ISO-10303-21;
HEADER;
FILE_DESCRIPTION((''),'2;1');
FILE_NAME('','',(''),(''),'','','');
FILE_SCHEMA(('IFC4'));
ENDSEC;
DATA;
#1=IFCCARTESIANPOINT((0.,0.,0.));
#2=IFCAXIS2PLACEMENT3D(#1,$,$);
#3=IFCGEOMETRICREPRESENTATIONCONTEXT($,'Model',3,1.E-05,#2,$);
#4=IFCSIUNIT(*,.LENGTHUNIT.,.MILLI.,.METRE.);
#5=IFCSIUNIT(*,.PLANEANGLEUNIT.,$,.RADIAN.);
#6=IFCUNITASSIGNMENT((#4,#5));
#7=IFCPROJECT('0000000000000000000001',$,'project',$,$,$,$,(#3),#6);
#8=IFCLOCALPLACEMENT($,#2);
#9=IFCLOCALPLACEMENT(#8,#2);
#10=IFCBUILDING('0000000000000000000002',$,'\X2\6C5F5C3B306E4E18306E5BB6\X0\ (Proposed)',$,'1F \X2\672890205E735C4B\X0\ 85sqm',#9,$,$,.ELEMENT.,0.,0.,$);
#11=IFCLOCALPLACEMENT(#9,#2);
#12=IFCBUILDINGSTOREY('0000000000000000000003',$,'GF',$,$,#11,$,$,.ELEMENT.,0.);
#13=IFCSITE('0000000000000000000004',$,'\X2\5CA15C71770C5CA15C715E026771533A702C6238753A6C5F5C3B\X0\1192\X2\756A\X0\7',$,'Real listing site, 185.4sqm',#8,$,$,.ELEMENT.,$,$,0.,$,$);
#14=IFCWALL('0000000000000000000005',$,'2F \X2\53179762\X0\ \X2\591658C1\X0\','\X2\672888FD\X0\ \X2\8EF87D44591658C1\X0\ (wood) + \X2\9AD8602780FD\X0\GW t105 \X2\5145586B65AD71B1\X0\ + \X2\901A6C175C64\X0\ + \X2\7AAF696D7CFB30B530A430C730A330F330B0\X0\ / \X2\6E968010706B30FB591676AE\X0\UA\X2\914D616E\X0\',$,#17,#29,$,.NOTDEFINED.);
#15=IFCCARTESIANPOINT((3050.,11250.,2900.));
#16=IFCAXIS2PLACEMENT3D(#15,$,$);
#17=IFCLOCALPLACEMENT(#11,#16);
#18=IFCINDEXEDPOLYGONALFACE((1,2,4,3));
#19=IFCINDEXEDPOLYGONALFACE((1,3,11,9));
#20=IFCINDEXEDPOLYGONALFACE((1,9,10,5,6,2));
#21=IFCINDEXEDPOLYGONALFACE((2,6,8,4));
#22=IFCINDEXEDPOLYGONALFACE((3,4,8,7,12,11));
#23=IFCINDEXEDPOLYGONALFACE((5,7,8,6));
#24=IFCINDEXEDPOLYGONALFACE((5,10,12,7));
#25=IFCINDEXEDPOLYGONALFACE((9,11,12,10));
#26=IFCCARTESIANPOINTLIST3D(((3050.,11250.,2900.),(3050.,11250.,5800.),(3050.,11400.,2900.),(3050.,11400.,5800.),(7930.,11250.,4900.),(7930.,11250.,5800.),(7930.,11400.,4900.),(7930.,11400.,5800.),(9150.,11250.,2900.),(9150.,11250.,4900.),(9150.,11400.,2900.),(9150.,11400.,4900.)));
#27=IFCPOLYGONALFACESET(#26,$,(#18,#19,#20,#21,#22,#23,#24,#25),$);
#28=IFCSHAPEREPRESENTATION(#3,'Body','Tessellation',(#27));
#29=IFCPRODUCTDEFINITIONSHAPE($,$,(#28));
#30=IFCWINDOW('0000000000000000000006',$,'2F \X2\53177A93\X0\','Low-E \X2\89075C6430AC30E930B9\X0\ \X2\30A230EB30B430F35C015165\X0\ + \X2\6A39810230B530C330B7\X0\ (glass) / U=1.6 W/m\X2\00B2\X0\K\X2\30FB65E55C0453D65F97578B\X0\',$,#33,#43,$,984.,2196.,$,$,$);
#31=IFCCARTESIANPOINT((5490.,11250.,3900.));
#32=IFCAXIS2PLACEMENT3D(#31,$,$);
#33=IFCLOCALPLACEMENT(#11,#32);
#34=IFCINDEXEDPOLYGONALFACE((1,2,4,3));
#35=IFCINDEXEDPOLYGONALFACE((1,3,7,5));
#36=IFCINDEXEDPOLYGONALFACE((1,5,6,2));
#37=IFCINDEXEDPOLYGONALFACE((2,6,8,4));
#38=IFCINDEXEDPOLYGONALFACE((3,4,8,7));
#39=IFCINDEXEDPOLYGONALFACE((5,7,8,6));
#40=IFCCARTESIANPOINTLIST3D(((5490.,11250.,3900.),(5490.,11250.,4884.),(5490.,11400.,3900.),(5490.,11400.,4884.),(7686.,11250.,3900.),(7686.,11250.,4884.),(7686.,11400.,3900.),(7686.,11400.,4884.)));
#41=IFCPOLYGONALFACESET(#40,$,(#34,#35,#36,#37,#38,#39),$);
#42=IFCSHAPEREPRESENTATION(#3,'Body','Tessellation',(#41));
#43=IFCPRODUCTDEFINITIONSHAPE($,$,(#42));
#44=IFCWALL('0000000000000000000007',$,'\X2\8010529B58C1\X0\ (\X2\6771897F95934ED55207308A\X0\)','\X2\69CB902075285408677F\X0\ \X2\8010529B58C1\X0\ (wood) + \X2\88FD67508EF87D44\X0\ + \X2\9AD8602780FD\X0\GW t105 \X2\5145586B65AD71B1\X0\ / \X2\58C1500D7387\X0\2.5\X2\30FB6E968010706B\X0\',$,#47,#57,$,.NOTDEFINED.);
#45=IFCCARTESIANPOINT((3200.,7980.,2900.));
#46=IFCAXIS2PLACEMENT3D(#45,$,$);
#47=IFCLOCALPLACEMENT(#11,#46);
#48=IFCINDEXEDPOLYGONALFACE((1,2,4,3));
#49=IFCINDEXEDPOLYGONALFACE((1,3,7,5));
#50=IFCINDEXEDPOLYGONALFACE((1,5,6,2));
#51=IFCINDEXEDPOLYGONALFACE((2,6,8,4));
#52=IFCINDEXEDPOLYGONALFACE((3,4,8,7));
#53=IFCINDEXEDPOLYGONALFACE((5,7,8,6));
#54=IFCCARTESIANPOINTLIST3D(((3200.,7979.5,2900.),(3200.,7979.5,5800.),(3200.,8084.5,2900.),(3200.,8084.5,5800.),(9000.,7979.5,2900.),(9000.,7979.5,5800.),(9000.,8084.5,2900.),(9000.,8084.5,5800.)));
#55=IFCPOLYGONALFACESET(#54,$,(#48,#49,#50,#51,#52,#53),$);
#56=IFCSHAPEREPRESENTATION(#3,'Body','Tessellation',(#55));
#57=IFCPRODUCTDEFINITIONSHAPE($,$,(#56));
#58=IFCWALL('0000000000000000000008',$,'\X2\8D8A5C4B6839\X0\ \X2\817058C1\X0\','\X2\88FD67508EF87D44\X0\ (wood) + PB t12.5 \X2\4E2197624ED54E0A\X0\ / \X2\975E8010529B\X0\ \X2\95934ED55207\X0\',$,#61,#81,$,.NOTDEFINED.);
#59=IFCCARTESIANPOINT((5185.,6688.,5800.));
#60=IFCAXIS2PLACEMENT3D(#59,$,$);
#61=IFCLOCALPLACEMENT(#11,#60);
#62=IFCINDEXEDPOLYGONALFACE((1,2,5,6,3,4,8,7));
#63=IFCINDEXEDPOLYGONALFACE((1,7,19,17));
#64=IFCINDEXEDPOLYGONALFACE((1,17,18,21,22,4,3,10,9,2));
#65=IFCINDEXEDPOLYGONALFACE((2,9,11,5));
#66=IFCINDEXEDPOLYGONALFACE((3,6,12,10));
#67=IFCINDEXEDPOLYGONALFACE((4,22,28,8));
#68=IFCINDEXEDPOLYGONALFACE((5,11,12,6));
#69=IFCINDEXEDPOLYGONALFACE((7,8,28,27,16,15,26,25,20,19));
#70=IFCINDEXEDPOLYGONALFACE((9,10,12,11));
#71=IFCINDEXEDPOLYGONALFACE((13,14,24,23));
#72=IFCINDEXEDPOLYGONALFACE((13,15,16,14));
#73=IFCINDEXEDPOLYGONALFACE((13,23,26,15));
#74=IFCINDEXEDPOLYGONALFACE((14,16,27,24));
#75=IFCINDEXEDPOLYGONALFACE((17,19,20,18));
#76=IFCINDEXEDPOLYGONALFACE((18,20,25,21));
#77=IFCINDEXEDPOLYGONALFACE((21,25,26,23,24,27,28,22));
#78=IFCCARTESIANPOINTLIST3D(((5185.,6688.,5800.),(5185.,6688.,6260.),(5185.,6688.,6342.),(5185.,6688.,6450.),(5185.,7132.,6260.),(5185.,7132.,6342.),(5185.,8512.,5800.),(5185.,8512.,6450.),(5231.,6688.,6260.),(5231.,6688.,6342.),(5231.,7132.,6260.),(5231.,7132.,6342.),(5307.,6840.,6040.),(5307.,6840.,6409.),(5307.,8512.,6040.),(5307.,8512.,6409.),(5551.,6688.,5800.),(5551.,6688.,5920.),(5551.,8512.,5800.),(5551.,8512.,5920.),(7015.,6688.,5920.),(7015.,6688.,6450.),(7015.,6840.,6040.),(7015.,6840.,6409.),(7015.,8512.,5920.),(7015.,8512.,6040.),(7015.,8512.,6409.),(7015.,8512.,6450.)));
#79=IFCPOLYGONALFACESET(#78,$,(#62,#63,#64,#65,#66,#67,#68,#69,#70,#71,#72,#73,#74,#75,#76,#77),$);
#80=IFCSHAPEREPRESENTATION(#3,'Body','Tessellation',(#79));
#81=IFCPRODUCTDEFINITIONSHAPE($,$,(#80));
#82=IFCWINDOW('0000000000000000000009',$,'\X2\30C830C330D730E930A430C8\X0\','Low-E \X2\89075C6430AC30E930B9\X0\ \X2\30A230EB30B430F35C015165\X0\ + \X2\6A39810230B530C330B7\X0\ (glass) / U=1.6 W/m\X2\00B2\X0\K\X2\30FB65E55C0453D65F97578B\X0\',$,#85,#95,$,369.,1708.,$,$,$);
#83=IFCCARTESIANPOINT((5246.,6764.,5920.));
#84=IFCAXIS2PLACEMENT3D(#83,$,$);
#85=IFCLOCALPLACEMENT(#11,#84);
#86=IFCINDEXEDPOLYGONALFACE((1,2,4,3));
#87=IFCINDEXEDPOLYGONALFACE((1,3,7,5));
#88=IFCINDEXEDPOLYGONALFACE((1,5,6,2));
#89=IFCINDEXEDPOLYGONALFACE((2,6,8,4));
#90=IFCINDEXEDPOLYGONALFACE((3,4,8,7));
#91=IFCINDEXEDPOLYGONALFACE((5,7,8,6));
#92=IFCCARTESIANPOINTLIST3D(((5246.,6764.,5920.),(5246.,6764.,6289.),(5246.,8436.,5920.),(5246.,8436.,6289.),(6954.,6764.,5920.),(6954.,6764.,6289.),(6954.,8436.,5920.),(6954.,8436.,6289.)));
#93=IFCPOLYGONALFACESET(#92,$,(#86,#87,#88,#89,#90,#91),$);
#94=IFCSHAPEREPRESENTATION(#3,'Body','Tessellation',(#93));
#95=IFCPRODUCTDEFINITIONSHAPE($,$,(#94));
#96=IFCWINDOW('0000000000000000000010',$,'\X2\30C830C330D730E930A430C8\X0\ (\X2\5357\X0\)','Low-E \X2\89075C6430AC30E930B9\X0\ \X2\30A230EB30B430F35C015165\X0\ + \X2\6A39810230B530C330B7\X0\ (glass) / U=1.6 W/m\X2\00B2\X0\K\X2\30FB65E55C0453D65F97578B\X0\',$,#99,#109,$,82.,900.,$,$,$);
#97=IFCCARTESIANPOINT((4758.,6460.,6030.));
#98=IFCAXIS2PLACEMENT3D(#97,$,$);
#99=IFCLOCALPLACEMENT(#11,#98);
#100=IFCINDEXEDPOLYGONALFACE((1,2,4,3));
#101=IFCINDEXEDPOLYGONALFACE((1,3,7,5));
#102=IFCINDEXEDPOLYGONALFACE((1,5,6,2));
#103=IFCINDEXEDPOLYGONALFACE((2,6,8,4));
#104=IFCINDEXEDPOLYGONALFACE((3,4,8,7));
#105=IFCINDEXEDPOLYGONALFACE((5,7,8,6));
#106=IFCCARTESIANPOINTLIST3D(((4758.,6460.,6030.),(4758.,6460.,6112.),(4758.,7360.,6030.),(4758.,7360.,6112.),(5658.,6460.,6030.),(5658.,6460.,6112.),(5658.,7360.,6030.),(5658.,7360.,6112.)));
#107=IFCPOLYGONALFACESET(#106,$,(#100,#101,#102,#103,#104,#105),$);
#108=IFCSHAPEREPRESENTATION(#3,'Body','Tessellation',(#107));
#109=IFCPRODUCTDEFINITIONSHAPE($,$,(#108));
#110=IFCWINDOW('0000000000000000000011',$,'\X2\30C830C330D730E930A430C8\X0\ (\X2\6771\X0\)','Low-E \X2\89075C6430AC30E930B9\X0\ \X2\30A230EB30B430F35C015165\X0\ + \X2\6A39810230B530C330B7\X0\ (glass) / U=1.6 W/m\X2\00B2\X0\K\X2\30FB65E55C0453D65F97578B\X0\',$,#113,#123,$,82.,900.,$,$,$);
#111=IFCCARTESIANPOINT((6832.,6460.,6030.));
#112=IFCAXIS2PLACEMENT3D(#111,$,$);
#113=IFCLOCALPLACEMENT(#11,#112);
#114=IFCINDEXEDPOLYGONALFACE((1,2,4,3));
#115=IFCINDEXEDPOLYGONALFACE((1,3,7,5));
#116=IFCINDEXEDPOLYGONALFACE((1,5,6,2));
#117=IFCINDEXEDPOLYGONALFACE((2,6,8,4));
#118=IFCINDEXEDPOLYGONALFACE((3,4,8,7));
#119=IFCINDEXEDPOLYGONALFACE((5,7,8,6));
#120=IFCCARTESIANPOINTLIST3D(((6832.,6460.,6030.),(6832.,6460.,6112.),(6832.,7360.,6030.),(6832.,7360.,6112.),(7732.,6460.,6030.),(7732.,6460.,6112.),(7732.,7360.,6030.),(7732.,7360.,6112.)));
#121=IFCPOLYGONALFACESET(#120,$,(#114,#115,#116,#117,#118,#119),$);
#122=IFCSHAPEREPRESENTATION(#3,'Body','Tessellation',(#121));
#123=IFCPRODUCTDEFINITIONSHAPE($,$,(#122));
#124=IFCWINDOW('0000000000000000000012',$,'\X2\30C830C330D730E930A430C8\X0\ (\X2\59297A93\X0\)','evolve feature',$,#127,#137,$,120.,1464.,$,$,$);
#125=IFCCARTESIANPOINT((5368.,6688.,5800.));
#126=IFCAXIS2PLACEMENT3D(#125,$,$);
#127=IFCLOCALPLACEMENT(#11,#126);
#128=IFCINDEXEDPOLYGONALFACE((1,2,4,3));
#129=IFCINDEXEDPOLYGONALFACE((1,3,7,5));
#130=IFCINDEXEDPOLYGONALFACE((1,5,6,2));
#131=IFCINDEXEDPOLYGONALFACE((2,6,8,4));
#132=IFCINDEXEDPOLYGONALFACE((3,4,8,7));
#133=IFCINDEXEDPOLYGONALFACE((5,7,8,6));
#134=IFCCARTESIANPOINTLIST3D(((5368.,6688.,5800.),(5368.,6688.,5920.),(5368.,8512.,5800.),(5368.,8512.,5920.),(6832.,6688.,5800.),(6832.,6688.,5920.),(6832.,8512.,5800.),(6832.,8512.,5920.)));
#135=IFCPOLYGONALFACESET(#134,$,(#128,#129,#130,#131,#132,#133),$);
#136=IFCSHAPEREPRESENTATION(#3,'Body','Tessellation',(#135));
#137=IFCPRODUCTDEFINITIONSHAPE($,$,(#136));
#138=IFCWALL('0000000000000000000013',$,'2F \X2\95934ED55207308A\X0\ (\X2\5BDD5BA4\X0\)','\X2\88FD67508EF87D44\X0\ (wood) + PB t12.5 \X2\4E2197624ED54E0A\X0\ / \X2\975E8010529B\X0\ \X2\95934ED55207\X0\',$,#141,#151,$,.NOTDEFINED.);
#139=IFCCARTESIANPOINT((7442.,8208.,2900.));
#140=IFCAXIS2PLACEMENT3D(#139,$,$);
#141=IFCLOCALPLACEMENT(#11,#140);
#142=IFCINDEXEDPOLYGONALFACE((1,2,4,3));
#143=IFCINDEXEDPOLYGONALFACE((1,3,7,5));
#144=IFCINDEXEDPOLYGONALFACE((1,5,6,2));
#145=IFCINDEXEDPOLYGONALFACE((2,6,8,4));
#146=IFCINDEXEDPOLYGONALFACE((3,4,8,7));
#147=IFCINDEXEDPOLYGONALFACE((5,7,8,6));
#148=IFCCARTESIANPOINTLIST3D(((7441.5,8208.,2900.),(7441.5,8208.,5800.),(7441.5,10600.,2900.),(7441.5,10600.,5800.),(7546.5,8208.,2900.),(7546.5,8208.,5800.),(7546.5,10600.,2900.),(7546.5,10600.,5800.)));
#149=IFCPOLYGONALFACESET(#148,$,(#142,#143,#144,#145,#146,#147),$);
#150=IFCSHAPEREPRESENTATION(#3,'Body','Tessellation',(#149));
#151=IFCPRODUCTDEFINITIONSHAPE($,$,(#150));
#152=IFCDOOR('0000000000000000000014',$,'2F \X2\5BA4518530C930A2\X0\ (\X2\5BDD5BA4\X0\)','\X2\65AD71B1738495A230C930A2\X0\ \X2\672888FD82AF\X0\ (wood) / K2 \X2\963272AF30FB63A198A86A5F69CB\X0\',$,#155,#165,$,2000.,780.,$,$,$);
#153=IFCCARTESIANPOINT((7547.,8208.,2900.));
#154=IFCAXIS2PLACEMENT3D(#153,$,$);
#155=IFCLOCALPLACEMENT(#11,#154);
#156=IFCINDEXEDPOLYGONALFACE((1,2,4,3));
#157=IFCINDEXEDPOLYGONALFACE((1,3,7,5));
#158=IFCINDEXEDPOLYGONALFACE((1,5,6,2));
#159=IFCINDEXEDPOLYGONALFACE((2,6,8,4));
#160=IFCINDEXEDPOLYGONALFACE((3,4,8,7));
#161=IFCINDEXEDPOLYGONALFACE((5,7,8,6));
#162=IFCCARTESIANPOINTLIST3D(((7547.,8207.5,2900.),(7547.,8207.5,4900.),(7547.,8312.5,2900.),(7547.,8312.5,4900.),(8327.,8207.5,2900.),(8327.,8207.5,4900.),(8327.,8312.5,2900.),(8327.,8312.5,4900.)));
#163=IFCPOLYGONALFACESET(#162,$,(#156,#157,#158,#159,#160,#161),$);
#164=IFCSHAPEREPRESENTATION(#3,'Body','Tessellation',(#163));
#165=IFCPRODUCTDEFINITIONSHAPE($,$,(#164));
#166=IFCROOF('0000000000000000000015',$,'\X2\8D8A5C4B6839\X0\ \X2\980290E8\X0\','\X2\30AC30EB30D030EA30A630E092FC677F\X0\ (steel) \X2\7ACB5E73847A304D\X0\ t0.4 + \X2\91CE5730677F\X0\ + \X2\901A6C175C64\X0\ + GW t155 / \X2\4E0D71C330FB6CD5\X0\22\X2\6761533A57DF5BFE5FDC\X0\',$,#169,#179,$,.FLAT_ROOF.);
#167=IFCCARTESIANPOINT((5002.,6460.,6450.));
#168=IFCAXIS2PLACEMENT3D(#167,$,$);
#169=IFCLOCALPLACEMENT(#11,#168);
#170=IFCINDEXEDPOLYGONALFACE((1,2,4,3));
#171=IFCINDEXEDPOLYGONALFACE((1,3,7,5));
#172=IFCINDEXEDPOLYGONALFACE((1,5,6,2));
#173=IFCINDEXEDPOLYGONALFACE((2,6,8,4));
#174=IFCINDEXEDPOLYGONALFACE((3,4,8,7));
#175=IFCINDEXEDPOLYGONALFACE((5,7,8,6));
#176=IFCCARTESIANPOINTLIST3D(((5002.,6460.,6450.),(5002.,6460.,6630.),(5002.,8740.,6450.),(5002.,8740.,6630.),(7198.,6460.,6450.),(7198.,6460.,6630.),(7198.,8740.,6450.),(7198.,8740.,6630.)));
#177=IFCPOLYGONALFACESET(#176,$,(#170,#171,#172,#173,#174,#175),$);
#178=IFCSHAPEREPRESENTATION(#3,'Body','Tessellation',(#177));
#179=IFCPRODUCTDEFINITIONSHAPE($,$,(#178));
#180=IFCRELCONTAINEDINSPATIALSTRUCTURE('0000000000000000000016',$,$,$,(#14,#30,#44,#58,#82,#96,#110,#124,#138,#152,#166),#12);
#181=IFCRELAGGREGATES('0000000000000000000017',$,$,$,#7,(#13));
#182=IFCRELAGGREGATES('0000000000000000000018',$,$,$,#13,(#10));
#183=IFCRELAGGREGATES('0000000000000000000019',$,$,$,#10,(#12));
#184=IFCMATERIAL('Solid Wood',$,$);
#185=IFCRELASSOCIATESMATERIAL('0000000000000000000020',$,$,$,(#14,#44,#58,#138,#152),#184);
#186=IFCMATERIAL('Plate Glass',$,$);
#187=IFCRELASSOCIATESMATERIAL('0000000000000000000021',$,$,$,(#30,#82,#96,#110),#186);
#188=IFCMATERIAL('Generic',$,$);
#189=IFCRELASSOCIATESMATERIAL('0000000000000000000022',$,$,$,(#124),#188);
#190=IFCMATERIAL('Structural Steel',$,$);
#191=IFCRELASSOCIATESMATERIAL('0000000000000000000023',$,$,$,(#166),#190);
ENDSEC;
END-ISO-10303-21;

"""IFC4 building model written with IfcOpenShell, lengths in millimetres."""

from ifc_helpers import new_model, si_unit, frame, frame_2d, origin, place, context, project, spatial, rectangle, extrude, material, element, fill, save


model = new_model("IFC4")

# Units and contexts
model_context = context("Model", 3, precision=1e-05, world=origin())
ifc_project = project(units=[si_unit("LENGTHUNIT", "METRE", prefix="MILLI"), si_unit("PLANEANGLEUNIT", "RADIAN")], contexts=[model_context])

# Site, building, storey
site_placement = place(None, origin())
site = spatial("IfcSite", under=ifc_project, at=site_placement, Name="岡山県岡山市東区瀬戸町江尻1192番7", ObjectType="Real listing site, 185.4sqm", CompositionType="ELEMENT", RefElevation=0.0)
building_placement = place(site_placement, origin())
building = spatial("IfcBuilding", under=site, at=building_placement, Name="江尻の丘の家 (Proposed)", ObjectType="1F 木造平屋 85sqm", CompositionType="ELEMENT", ElevationOfRefHeight=0.0, ElevationOfTerrain=0.0)
storey_placement = place(building_placement, origin())
storey = spatial("IfcBuildingStorey", under=building, at=storey_placement, Name="GF", CompositionType="ELEMENT", Elevation=0.0)

# Wall, opening, window
ifc_material_1 = material(Name="Solid Wood")
wall_1_placement = place(storey_placement, frame((3050.0, 11250.0, 2900.0)))
wall_1 = element("IfcWall", 1, at=wall_1_placement, inside=storey, material=ifc_material_1, Name="2F 北面 外壁", Description="木製 軸組外壁 (wood) + 高性能GW t105 充填断熱 + 通気層 + 窯業系サイディング / 準耐火・外皮UA配慮", PredefinedType="NOTDEFINED", context=model_context, shape_type="SweptSolid", body=[
    extrude(rectangle(XDim=6100.0, YDim=150.0, at=frame_2d((3050.0, 75.0))), frame((3050.0, 11250.0, 2900.0)), (0.0, 0.0, 1.0), 2900.0),
])
opening_1_placement = place(storey_placement, frame((5490.0, 11250.0, 3900.0)))
opening_1 = element("IfcOpeningElement", 2, at=opening_1_placement, cuts=wall_1, PredefinedType="NOTDEFINED", context=model_context, shape_type="SweptSolid", body=[
    extrude(rectangle(XDim=2196.0, YDim=150.0, at=frame_2d((1098.0, 75.0))), frame((5490.0, 11250.0, 3900.0)), (0.0, 0.0, 1.0), 984.0),
])
ifc_material_2 = material(Name="Plate Glass")
window_1_placement = place(storey_placement, frame((5490.0, 11250.0, 3900.0)))
window_1 = element("IfcWindow", 3, at=window_1_placement, inside=storey, material=ifc_material_2, Name="2F 北窓", Description="Low-E 複層ガラス アルゴン封入 + 樹脂サッシ (glass) / U=1.6 W/m²K・日射取得型", OverallHeight=984.0, OverallWidth=2196.0, context=model_context, shape_type="SweptSolid", body=[
    extrude(rectangle(XDim=2196.0, YDim=150.0, at=frame_2d((1098.0, 75.0))), frame((5490.0, 11250.0, 3900.0)), (0.0, 0.0, 1.0), 984.0),
])
fill(opening_1, window_1)

# Wall
wall_2_placement = place(storey_placement, frame((3200.0, 7980.0, 2900.0)))
element("IfcWall", 4, at=wall_2_placement, inside=storey, material=ifc_material_1, Name="耐力壁 (東西間仕切り)", Description="構造用合板 耐力壁 (wood) + 製材軸組 + 高性能GW t105 充填断熱 / 壁倍率2.5・準耐火", PredefinedType="NOTDEFINED", context=model_context, shape_type="SweptSolid", body=[
    extrude(rectangle(XDim=5800.0, YDim=105.0, at=frame_2d((2900.0, 52.0))), frame((3200.0, 7980.0, 2900.0)), (0.0, 0.0, 1.0), 2900.0),
])

# Wall, openings, windows
wall_3_placement = place(storey_placement, frame((5185.0, 6688.0, 5800.0)))
wall_3 = element("IfcWall", 5, at=wall_3_placement, inside=storey, material=ifc_material_1, Name="越屋根 腰壁", Description="製材軸組 (wood) + PB t12.5 両面仕上 / 非耐力 間仕切", PredefinedType="NOTDEFINED", context=model_context, shape_type="SweptSolid", body=[
    extrude(rectangle(XDim=1830.0, YDim=1824.0, at=frame_2d((915.0, 912.0))), frame((5185.0, 6688.0, 5800.0)), (0.0, 0.0, 1.0), 650.0),
])
opening_2_placement = place(storey_placement, frame((5246.0, 6764.0, 5920.0)))
opening_2 = element("IfcOpeningElement", 6, at=opening_2_placement, cuts=wall_3, PredefinedType="NOTDEFINED", context=model_context, shape_type="SweptSolid", body=[
    extrude(rectangle(XDim=1708.0, YDim=1672.0, at=frame_2d((854.0, 836.0))), frame((5246.0, 6764.0, 5920.0)), (0.0, 0.0, 1.0), 369.0),
])
opening_3_placement = place(storey_placement, frame((4758.0, 6460.0, 6030.0)))
opening_3 = element("IfcOpeningElement", 7, at=opening_3_placement, cuts=wall_3, PredefinedType="NOTDEFINED", context=model_context, shape_type="SweptSolid", body=[
    extrude(rectangle(XDim=900.0, YDim=900.0, at=frame_2d((450.0, 450.0))), frame((4758.0, 6460.0, 6030.0)), (0.0, 0.0, 1.0), 82.0),
])
opening_4_placement = place(storey_placement, frame((6832.0, 6460.0, 6030.0)))
opening_4 = element("IfcOpeningElement", 8, at=opening_4_placement, cuts=wall_3, PredefinedType="NOTDEFINED", context=model_context, shape_type="SweptSolid", body=[
    extrude(rectangle(XDim=900.0, YDim=900.0, at=frame_2d((450.0, 450.0))), frame((6832.0, 6460.0, 6030.0)), (0.0, 0.0, 1.0), 82.0),
])
opening_5_placement = place(storey_placement, frame((5368.0, 6688.0, 5800.0)))
opening_5 = element("IfcOpeningElement", 9, at=opening_5_placement, cuts=wall_3, PredefinedType="NOTDEFINED", context=model_context, shape_type="SweptSolid", body=[
    extrude(rectangle(XDim=1464.0, YDim=1824.0, at=frame_2d((732.0, 912.0))), frame((5368.0, 6688.0, 5800.0)), (0.0, 0.0, 1.0), 120.0),
])
window_2_placement = place(storey_placement, frame((5246.0, 6764.0, 5920.0)))
window_2 = element("IfcWindow", 10, at=window_2_placement, inside=storey, material=ifc_material_2, Name="トップライト", Description="Low-E 複層ガラス アルゴン封入 + 樹脂サッシ (glass) / U=1.6 W/m²K・日射取得型", OverallHeight=369.0, OverallWidth=1708.0, context=model_context, shape_type="SweptSolid", body=[
    extrude(rectangle(XDim=1708.0, YDim=1672.0, at=frame_2d((854.0, 836.0))), frame((5246.0, 6764.0, 5920.0)), (0.0, 0.0, 1.0), 369.0),
])
fill(opening_2, window_2)
window_3_placement = place(storey_placement, frame((4758.0, 6460.0, 6030.0)))
window_3 = element("IfcWindow", 11, at=window_3_placement, inside=storey, material=ifc_material_2, Name="トップライト (南)", Description="Low-E 複層ガラス アルゴン封入 + 樹脂サッシ (glass) / U=1.6 W/m²K・日射取得型", OverallHeight=82.0, OverallWidth=900.0, context=model_context, shape_type="SweptSolid", body=[
    extrude(rectangle(XDim=900.0, YDim=900.0, at=frame_2d((450.0, 450.0))), frame((4758.0, 6460.0, 6030.0)), (0.0, 0.0, 1.0), 82.0),
])
fill(opening_3, window_3)
window_4_placement = place(storey_placement, frame((6832.0, 6460.0, 6030.0)))
window_4 = element("IfcWindow", 12, at=window_4_placement, inside=storey, material=ifc_material_2, Name="トップライト (東)", Description="Low-E 複層ガラス アルゴン封入 + 樹脂サッシ (glass) / U=1.6 W/m²K・日射取得型", OverallHeight=82.0, OverallWidth=900.0, context=model_context, shape_type="SweptSolid", body=[
    extrude(rectangle(XDim=900.0, YDim=900.0, at=frame_2d((450.0, 450.0))), frame((6832.0, 6460.0, 6030.0)), (0.0, 0.0, 1.0), 82.0),
])
fill(opening_4, window_4)
ifc_material_3 = material(Name="Generic")
window_5_placement = place(storey_placement, frame((5368.0, 6688.0, 5800.0)))
window_5 = element("IfcWindow", 13, at=window_5_placement, inside=storey, material=ifc_material_3, Name="トップライト (天窓)", Description="evolve feature", OverallHeight=120.0, OverallWidth=1464.0, context=model_context, shape_type="SweptSolid", body=[
    extrude(rectangle(XDim=1464.0, YDim=1824.0, at=frame_2d((732.0, 912.0))), frame((5368.0, 6688.0, 5800.0)), (0.0, 0.0, 1.0), 120.0),
])
fill(opening_5, window_5)

# Wall
wall_4_placement = place(storey_placement, frame((7442.0, 8208.0, 2900.0)))
element("IfcWall", 14, at=wall_4_placement, inside=storey, material=ifc_material_1, Name="2F 間仕切り (寝室)", Description="製材軸組 (wood) + PB t12.5 両面仕上 / 非耐力 間仕切", PredefinedType="NOTDEFINED", context=model_context, shape_type="SweptSolid", body=[
    extrude(rectangle(XDim=105.0, YDim=2392.0, at=frame_2d((52.0, 1196.0))), frame((7442.0, 8208.0, 2900.0)), (0.0, 0.0, 1.0), 2900.0),
])

# Door
door_placement = place(storey_placement, frame((7547.0, 8208.0, 2900.0)))
element("IfcDoor", 15, at=door_placement, inside=storey, material=ifc_material_1, Name="2F 室内ドア (寝室)", Description="断熱玄関ドア 木製芯 (wood) / K2 防犯・採風機構", OverallHeight=2000.0, OverallWidth=780.0, context=model_context, shape_type="SweptSolid", body=[
    extrude(rectangle(XDim=780.0, YDim=105.0, at=frame_2d((390.0, 52.0))), frame((7547.0, 8208.0, 2900.0)), (0.0, 0.0, 1.0), 2000.0),
])

# Roof
ifc_material_4 = material(Name="Structural Steel")
roof_placement = place(storey_placement, frame((5002.0, 6460.0, 6450.0)))
element("IfcRoof", 16, at=roof_placement, inside=storey, material=ifc_material_4, Name="越屋根 頂部", Description="ガルバリウム鋼板 (steel) 立平葺き t0.4 + 野地板 + 通気層 + GW t155 / 不燃・法22条区域対応", PredefinedType="FLAT_ROOF", context=model_context, shape_type="SweptSolid", body=[
    extrude(rectangle(XDim=2196.0, YDim=2280.0, at=frame_2d((1098.0, 1140.0))), frame((5002.0, 6460.0, 6450.0)), (0.0, 0.0, 1.0), 180.0),
])

save(model, "model.ifc")
